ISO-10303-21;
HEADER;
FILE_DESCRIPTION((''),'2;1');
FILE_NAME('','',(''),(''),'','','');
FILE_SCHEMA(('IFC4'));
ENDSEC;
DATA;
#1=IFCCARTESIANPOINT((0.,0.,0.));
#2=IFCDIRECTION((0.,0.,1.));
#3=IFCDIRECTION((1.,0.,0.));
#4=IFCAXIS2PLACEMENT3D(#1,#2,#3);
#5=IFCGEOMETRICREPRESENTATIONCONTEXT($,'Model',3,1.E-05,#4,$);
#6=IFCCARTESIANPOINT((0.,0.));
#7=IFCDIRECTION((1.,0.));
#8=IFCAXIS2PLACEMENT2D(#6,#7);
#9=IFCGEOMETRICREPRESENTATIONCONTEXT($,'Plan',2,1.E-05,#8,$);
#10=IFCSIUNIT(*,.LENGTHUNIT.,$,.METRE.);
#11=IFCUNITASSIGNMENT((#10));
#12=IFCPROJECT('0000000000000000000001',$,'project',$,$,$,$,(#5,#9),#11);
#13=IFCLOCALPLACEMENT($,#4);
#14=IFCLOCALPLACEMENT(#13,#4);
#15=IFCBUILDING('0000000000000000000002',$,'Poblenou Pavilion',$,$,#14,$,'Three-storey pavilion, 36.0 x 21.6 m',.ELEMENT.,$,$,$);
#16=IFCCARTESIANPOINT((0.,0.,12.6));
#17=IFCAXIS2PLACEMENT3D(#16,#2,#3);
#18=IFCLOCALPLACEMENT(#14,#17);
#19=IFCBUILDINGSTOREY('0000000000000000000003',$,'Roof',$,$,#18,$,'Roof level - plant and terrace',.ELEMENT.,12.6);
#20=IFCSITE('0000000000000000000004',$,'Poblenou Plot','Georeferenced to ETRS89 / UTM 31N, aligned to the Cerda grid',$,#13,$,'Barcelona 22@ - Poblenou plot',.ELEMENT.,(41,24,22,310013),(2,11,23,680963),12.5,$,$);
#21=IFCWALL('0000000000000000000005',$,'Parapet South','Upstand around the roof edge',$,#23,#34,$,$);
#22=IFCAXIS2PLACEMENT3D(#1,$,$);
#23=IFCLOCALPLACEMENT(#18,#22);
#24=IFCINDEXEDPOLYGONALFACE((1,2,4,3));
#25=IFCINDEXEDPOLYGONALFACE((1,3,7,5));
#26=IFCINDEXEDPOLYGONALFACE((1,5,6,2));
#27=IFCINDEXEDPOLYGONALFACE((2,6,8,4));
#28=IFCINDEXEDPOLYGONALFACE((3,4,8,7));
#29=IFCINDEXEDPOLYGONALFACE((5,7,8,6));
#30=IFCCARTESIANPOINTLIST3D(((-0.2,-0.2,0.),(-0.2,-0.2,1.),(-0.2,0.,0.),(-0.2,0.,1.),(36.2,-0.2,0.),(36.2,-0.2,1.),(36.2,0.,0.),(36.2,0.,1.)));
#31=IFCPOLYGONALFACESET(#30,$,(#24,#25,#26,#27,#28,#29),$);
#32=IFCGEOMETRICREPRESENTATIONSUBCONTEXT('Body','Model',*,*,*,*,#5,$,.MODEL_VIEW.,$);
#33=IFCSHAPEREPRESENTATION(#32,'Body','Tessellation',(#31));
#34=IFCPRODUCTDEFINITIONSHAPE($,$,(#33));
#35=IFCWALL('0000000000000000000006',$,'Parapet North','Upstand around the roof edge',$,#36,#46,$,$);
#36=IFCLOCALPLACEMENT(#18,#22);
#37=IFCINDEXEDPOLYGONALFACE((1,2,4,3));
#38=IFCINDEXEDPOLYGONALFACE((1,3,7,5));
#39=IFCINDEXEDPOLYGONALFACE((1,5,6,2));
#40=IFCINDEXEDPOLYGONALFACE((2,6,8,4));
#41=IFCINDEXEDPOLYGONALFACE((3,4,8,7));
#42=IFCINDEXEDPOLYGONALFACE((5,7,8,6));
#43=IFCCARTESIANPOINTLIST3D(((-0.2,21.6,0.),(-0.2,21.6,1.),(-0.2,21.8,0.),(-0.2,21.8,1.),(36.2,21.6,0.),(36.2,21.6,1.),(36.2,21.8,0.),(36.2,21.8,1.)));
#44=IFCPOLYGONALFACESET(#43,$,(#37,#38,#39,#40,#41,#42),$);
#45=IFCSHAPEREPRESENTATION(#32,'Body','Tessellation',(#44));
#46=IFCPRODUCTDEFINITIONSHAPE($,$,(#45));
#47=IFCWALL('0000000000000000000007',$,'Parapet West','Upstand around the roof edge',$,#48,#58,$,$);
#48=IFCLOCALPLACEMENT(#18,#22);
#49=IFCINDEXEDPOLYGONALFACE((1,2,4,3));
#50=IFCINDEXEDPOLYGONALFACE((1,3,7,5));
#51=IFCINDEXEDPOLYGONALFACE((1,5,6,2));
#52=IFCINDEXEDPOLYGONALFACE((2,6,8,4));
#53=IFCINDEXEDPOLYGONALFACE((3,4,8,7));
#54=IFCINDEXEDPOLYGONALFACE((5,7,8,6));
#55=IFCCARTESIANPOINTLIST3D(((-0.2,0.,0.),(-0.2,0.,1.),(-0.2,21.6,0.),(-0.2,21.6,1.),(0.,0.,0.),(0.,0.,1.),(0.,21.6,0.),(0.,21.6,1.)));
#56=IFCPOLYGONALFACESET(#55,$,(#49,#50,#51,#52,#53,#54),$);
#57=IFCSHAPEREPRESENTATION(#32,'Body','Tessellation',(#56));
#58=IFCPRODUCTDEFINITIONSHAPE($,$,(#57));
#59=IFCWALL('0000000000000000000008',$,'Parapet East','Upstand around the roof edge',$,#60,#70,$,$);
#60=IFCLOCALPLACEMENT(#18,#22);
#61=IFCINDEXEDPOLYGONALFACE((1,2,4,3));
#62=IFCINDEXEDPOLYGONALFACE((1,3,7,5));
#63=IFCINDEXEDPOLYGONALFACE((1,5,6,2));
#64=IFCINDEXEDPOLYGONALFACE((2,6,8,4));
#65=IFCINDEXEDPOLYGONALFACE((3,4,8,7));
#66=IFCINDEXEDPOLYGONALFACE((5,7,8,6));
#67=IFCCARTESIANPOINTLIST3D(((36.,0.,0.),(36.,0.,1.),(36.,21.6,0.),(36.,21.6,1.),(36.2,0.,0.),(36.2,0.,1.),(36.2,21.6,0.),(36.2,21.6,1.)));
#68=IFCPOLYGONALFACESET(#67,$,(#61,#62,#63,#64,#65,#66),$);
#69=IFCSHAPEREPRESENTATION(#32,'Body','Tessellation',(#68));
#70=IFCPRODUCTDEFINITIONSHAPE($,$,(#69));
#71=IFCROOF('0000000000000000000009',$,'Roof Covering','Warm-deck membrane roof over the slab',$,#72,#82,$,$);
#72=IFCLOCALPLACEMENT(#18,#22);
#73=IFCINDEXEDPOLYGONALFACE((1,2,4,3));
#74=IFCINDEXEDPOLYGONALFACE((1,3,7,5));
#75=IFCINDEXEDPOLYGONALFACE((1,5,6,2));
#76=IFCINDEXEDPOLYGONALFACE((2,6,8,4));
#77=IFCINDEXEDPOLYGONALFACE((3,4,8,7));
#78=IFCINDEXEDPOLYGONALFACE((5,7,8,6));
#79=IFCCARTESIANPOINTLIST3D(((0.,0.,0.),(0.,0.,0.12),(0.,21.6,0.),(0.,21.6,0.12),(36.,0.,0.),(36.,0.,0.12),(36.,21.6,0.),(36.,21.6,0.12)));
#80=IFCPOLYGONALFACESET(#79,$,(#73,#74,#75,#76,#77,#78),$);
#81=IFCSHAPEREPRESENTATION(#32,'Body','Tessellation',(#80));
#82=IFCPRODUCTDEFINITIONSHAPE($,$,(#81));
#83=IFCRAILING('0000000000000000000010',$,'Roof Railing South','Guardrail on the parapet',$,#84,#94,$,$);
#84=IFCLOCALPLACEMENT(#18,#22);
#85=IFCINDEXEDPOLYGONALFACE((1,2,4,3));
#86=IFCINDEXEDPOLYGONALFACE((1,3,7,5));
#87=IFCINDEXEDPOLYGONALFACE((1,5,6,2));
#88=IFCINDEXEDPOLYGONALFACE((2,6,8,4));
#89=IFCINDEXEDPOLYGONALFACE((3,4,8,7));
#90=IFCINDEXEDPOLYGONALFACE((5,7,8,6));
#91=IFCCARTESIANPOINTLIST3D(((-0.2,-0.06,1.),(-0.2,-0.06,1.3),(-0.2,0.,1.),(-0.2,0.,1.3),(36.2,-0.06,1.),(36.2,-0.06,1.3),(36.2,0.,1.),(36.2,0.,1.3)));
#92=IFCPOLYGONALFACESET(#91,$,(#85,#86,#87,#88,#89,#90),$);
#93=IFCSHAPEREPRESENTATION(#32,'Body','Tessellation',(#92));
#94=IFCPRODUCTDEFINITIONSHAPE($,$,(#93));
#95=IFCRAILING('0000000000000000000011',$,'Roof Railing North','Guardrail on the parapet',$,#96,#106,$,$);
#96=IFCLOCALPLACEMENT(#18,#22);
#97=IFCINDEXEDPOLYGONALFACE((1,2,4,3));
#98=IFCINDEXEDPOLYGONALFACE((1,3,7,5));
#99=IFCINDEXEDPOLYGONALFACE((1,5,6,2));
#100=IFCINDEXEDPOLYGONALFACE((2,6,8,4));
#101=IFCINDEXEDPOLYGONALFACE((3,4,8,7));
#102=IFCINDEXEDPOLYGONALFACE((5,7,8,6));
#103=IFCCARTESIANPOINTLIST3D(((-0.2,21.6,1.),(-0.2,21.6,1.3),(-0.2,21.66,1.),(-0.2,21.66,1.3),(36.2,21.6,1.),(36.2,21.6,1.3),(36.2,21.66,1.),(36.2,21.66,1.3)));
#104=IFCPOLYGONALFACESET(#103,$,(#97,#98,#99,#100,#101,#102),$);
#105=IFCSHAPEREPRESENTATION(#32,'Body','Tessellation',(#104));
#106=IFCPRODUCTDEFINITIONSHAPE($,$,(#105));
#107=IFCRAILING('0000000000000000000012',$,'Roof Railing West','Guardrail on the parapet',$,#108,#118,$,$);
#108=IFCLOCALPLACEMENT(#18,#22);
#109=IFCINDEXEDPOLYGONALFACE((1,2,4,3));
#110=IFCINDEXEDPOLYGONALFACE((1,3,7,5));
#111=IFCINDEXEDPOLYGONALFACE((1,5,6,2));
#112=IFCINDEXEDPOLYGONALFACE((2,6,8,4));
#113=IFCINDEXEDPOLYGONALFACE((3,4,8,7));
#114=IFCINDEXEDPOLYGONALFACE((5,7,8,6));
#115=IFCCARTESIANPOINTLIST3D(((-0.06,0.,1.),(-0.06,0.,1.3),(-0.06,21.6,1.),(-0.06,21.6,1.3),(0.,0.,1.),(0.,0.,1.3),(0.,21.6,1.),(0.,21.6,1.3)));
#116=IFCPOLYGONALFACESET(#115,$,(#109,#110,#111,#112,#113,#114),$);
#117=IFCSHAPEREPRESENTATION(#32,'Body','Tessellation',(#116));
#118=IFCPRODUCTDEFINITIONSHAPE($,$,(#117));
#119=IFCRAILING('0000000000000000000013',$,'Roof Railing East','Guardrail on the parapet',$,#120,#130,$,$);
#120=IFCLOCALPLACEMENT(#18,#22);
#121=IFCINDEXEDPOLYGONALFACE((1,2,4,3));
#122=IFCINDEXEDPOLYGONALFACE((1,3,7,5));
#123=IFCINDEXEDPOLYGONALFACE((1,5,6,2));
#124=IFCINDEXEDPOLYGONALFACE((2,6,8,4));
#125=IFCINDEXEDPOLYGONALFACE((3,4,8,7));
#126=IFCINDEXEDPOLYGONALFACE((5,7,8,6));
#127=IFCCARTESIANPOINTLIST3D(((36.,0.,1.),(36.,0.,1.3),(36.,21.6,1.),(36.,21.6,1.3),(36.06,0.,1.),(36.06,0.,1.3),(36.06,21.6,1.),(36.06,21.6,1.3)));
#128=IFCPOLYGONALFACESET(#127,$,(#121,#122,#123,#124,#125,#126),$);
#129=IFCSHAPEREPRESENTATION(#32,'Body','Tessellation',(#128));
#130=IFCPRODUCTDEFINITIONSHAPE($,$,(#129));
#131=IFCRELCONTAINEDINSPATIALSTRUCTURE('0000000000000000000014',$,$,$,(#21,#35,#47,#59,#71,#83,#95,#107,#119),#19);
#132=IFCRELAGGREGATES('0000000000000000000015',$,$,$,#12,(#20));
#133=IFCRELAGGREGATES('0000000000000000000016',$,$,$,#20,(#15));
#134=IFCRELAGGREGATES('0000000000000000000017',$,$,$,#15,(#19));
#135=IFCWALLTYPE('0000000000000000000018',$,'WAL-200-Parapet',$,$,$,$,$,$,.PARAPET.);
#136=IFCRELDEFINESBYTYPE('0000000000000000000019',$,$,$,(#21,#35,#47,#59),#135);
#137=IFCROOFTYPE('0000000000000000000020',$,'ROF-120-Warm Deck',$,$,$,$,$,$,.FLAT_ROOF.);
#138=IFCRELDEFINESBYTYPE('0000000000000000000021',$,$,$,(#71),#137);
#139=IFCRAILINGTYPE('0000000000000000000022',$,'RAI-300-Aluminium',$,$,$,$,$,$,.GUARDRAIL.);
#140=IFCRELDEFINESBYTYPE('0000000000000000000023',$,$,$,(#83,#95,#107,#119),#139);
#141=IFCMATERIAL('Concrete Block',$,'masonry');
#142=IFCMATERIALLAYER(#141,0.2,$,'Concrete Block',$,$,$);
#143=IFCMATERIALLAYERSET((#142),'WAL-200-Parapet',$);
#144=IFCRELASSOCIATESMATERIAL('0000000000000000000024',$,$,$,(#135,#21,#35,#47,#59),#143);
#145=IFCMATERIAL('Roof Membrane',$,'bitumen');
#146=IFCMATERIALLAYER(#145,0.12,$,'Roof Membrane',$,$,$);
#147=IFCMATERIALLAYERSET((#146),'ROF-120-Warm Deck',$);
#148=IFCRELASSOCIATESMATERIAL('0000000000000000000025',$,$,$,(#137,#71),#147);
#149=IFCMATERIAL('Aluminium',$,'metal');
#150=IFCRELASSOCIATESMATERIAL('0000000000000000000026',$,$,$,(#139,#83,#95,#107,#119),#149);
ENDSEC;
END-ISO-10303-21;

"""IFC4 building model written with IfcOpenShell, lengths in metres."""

from ifc_helpers import new_model, si_unit, frame, origin_with_axes, origin_2d_with_axis, place, context, subcontext, project, spatial, line, indexed_curve, outline, extrude, material, layer, layer_set, layer_usage, type_object, element, save


model = new_model("IFC4")

# Units and contexts
model_context = context("Model", 3, precision=1e-05, world=origin_with_axes())
plan_context = context("Plan", 2, precision=1e-05, world=origin_2d_with_axis())
body_context = subcontext(model_context, "Body", "Model", "MODEL_VIEW")
ifc_project = project(units=[si_unit("LENGTHUNIT", "METRE")], contexts=[model_context, plan_context])

# Site, building, storey
site_placement = place(None, origin_with_axes())
site = spatial("IfcSite", under=ifc_project, at=site_placement, Name="Poblenou Plot", Description="Georeferenced to ETRS89 / UTM 31N, aligned to the Cerda grid", LongName="Barcelona 22@ - Poblenou plot", CompositionType="ELEMENT", RefLatitude=(41, 24, 22, 310013), RefLongitude=(2, 11, 23, 680963), RefElevation=12.5)
building_placement = place(site_placement, origin_with_axes())
building = spatial("IfcBuilding", under=site, at=building_placement, Name="Poblenou Pavilion", LongName="Three-storey pavilion, 36.0 x 21.6 m", CompositionType="ELEMENT")
storey_placement = place(building_placement, frame((0.0, 0.0, 12.6), z_axis=(0.0, 0.0, 1.0), x_axis=(1.0, 0.0, 0.0)))
storey = spatial("IfcBuildingStorey", under=building, at=storey_placement, Name="Roof", LongName="Roof level - plant and terrace", CompositionType="ELEMENT", Elevation=12.6)

# Walls
ifc_material_1 = material(Name="Concrete Block", Category="masonry")
ifc_layer_1 = layer(ifc_material_1, 0.2, Name="Concrete Block")
ifc_layer_set_1 = layer_set([ifc_layer_1], Name="WAL-200-Parapet")
ifc_layer_usage_1 = layer_usage(ifc_layer_set_1, "AXIS2", "POSITIVE", 0.0)
wall_type = type_object("IfcWallType", Name="WAL-200-Parapet", PredefinedType="PARAPET", material=ifc_layer_set_1)
wall_1_placement = place(storey_placement, frame((36.2, 0.0, 0.0), z_axis=(0.0, 0.0, 1.0), x_axis=(-1.0, 0.0, 0.0)))
element("IfcWall", 1, at=wall_1_placement, inside=storey, type_object=wall_type, material=ifc_layer_usage_1, Name="Parapet South", Description="Upstand around the roof edge", context=body_context, shape_type="SweptSolid", body=[
    extrude(outline(indexed_curve([(0.0, 0.0), (36.4, 0.0), (36.4, 0.2), (0.0, 0.2)], segments=[line(1, 2, 3, 4, 1)])), origin_with_axes(), (0.0, 0.0, 1.0), 1.0),
])
ifc_layer_usage_2 = layer_usage(ifc_layer_set_1, "AXIS2", "POSITIVE", 0.0)
wall_2_placement = place(storey_placement, frame((-0.2, 21.6, 0.0), z_axis=(0.0, 0.0, 1.0), x_axis=(1.0, 0.0, 0.0)))
element("IfcWall", 2, at=wall_2_placement, inside=storey, type_object=wall_type, material=ifc_layer_usage_2, Name="Parapet North", Description="Upstand around the roof edge", context=body_context, shape_type="SweptSolid", body=[
    extrude(outline(indexed_curve([(0.0, 0.0), (36.4, 0.0), (36.4, 0.2), (0.0, 0.2)], segments=[line(1, 2, 3, 4, 1)])), origin_with_axes(), (0.0, 0.0, 1.0), 1.0),
])
ifc_layer_usage_3 = layer_usage(ifc_layer_set_1, "AXIS2", "POSITIVE", 0.0)
wall_3_placement = place(storey_placement, frame((0.0, 0.0, 0.0), z_axis=(0.0, 0.0, 1.0), x_axis=(0.0, 1.0, 0.0)))
element("IfcWall", 3, at=wall_3_placement, inside=storey, type_object=wall_type, material=ifc_layer_usage_3, Name="Parapet West", Description="Upstand around the roof edge", context=body_context, shape_type="SweptSolid", body=[
    extrude(outline(indexed_curve([(0.0, 0.0), (21.6, 0.0), (21.6, 0.2), (0.0, 0.2)], segments=[line(1, 2, 3, 4, 1)])), origin_with_axes(), (0.0, 0.0, 1.0), 1.0),
])
ifc_layer_usage_4 = layer_usage(ifc_layer_set_1, "AXIS2", "POSITIVE", 0.0)
wall_4_placement = place(storey_placement, frame((36.0, 21.6, 0.0), z_axis=(0.0, 0.0, 1.0), x_axis=(0.0, -1.0, 0.0)))
element("IfcWall", 4, at=wall_4_placement, inside=storey, type_object=wall_type, material=ifc_layer_usage_4, Name="Parapet East", Description="Upstand around the roof edge", context=body_context, shape_type="SweptSolid", body=[
    extrude(outline(indexed_curve([(0.0, 0.0), (21.6, 0.0), (21.6, 0.2), (0.0, 0.2)], segments=[line(1, 2, 3, 4, 1)])), origin_with_axes(), (0.0, 0.0, 1.0), 1.0),
])

# Roof
ifc_material_2 = material(Name="Roof Membrane", Category="bitumen")
ifc_layer_2 = layer(ifc_material_2, 0.12, Name="Roof Membrane")
ifc_layer_set_2 = layer_set([ifc_layer_2], Name="ROF-120-Warm Deck")
ifc_layer_usage_5 = layer_usage(ifc_layer_set_2, "AXIS3", "POSITIVE", 0.0)
roof_type = type_object("IfcRoofType", Name="ROF-120-Warm Deck", PredefinedType="FLAT_ROOF", material=ifc_layer_set_2)
roof_placement = place(storey_placement, origin_with_axes())
element("IfcRoof", 5, at=roof_placement, inside=storey, type_object=roof_type, material=ifc_layer_usage_5, Name="Roof Covering", Description="Warm-deck membrane roof over the slab", context=body_context, shape_type="SweptSolid", body=[
    extrude(outline(indexed_curve([(0.0, 0.0), (36.0, 0.0), (36.0, 21.6), (0.0, 21.6)], segments=[line(1, 2, 3, 4, 1)])), origin_with_axes(), (0.0, 0.0, 1.0), 0.12),
])

# Railings
ifc_material_3 = material(Name="Aluminium", Category="metal")
railing_type = type_object("IfcRailingType", Name="RAI-300-Aluminium", PredefinedType="GUARDRAIL", material=ifc_material_3)
for number, where, z_axis, x_axis, name in (
    (6, (36.2, 0.0, 1.0), (0.0, 0.0, 1.0), (-1.0, 0.0, 0.0), "Roof Railing South"),
    (7, (-0.2, 21.6, 1.0), (0.0, 0.0, 1.0), (1.0, 0.0, 0.0), "Roof Railing North"),
):
    element("IfcRailing", number, at=place(storey_placement, frame(where, z_axis=z_axis, x_axis=x_axis)), inside=storey, type_object=railing_type, material=ifc_material_3, Name=name, Description="Guardrail on the parapet", context=body_context, shape_type="SweptSolid", body=[
        extrude(outline(indexed_curve([(0.0, 0.0), (36.4, 0.0), (36.4, 0.06), (0.0, 0.06)], segments=[line(1, 2, 3, 4, 1)])), origin_with_axes(), (0.0, 0.0, 1.0), 0.3),
    ])
for number, where, z_axis, x_axis, name in (
    (8, (0.0, 0.0, 1.0), (0.0, 0.0, 1.0), (0.0, 1.0, 0.0), "Roof Railing West"),
    (9, (36.0, 21.6, 1.0), (0.0, 0.0, 1.0), (0.0, -1.0, 0.0), "Roof Railing East"),
):
    element("IfcRailing", number, at=place(storey_placement, frame(where, z_axis=z_axis, x_axis=x_axis)), inside=storey, type_object=railing_type, material=ifc_material_3, Name=name, Description="Guardrail on the parapet", context=body_context, shape_type="SweptSolid", body=[
        extrude(outline(indexed_curve([(0.0, 0.0), (21.6, 0.0), (21.6, 0.06), (0.0, 0.06)], segments=[line(1, 2, 3, 4, 1)])), origin_with_axes(), (0.0, 0.0, 1.0), 0.3),
    ])

save(model, "model.ifc")
